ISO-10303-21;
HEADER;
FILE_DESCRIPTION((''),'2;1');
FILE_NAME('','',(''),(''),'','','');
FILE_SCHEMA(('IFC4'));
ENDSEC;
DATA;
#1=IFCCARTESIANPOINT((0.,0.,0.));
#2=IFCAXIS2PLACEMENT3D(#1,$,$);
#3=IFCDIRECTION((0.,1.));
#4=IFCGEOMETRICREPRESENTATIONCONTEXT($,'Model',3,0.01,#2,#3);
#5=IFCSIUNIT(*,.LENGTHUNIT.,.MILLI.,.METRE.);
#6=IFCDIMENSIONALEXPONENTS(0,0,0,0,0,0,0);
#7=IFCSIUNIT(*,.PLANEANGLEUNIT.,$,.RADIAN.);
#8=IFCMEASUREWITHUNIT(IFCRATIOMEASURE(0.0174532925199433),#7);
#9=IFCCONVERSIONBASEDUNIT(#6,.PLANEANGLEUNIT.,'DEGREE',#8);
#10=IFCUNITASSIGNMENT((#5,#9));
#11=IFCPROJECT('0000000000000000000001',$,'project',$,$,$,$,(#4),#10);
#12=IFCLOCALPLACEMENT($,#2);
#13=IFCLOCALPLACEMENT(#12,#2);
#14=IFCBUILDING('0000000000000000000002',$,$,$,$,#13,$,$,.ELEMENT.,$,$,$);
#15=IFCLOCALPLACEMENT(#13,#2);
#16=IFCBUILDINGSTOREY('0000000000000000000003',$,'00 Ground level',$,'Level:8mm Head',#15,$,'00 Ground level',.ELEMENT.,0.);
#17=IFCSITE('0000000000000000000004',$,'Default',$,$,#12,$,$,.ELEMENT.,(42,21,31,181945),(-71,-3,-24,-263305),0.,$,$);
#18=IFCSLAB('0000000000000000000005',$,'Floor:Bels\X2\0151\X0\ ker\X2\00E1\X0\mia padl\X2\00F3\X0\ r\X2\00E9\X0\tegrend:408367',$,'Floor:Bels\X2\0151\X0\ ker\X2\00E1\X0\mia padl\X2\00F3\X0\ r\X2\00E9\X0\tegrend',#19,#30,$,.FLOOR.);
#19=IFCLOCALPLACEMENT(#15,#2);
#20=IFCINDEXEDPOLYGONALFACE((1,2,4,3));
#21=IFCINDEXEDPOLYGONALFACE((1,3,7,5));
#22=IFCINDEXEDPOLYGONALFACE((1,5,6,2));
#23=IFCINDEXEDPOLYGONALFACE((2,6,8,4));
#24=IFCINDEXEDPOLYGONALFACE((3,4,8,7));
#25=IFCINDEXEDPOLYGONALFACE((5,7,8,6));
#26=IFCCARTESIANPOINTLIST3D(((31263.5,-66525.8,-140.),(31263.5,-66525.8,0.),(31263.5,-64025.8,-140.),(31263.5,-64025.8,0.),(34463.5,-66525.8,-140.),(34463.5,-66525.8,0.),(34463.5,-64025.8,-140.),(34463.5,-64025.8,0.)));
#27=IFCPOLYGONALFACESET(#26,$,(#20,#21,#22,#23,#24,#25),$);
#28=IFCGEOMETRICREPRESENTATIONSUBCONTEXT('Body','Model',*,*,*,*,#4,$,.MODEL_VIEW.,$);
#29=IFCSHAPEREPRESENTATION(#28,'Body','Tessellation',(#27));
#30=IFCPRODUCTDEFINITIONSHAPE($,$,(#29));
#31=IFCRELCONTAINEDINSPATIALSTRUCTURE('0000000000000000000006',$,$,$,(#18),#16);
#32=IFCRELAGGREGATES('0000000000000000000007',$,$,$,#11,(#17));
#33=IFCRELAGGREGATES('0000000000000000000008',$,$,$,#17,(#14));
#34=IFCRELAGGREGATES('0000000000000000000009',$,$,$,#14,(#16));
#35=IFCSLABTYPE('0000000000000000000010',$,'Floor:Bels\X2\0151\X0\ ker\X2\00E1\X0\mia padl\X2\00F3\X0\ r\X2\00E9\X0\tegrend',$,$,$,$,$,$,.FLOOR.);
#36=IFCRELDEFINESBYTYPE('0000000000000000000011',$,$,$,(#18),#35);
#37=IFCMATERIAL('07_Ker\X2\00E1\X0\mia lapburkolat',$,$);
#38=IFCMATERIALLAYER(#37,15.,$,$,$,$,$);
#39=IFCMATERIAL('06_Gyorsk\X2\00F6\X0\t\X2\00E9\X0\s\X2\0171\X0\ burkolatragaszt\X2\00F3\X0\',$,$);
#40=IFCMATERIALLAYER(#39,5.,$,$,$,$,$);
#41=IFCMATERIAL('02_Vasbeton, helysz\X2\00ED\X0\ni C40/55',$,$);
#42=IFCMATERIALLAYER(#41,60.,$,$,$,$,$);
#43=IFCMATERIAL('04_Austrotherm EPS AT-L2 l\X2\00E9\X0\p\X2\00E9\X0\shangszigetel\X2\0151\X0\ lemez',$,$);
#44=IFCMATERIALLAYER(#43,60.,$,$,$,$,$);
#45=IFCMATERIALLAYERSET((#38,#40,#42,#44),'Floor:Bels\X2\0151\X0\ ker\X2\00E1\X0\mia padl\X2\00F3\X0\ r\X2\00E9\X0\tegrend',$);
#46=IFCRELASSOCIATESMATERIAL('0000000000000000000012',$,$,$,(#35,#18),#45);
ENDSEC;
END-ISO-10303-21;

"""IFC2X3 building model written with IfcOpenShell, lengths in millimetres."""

from ifc_helpers import new_model, entity, si_unit, converted_unit, direction, frame, frame_2d, origin, place, context, subcontext, project, spatial, rectangle, extrude, material, layer, layer_set, layer_usage, type_object, element, save


model = new_model("IFC2X3")

# Units and contexts
model_context = context("Model", 3, precision=0.01, world=origin(), true_north=direction((0.0, 1.0)))
body_context = subcontext(model_context, "Body", "Model", "MODEL_VIEW")
ifc_project = project(units=[si_unit("LENGTHUNIT", "METRE", prefix="MILLI"), converted_unit("PLANEANGLEUNIT", "DEGREE", entity("IfcRatioMeasure", 0.0174532925199433), si_unit("PLANEANGLEUNIT", "RADIAN"), dimensions=[0, 0, 0, 0, 0, 0, 0])], contexts=[model_context])

# Site, building, storey
site_placement = place(None, origin())
site = spatial("IfcSite", under=ifc_project, at=site_placement, Name="Default", CompositionType="ELEMENT", RefLatitude=(42, 21, 31, 181945), RefLongitude=(-71, -3, -24, -263305), RefElevation=0.0)
building_placement = place(site_placement, origin())
building = spatial("IfcBuilding", under=site, at=building_placement, CompositionType="ELEMENT")
storey_placement = place(building_placement, origin())
storey = spatial("IfcBuildingStorey", under=building, at=storey_placement, Name="00 Ground level", ObjectType="Level:8mm Head", LongName="00 Ground level", CompositionType="ELEMENT", Elevation=0.0)

# Slab
ifc_material_1 = material(Name="07_Kerámia lapburkolat")
ifc_layer_1 = layer(ifc_material_1, 15.0)
ifc_material_2 = material(Name="06_Gyorskötésű burkolatragasztó")
ifc_layer_2 = layer(ifc_material_2, 5.0)
ifc_material_3 = material(Name="02_Vasbeton, helyszíni C40/55")
ifc_layer_3 = layer(ifc_material_3, 60.0)
ifc_material_4 = material(Name="04_Austrotherm EPS AT-L2 lépéshangszigetelő lemez")
ifc_layer_4 = layer(ifc_material_4, 60.0)
ifc_layer_set = layer_set([ifc_layer_1, ifc_layer_2, ifc_layer_3, ifc_layer_4], Name="Floor:Belső kerámia padló rétegrend")
ifc_layer_usage_1 = layer_usage(ifc_layer_set, "AXIS3", "POSITIVE", 0.0)
slab_type_1 = type_object("IfcSlabType", Name="Floor:Belső kerámia padló rétegrend", PredefinedType="FLOOR", material=ifc_layer_set)
slab_1_placement = place(storey_placement, origin())
element("IfcSlab", 1, at=slab_1_placement, inside=storey, type_object=slab_type_1, material=ifc_layer_usage_1, Name="Floor:Belső kerámia padló rétegrend:408367", ObjectType="Floor:Belső kerámia padló rétegrend", PredefinedType="FLOOR", context=body_context, shape_type="SweptSolid", body=[
    extrude(rectangle(XDim=2500.0, YDim=3200.0, at=frame_2d((0.0, 0.0), x_axis=(1.0, 0.0))), frame((32863.5, -65275.8, 0.0), z_axis=(0.0, 0.0, -1.0), x_axis=(0.0, 1.0, 0.0)), (0.0, 0.0, 1.0), 140.0),
])

save(model, "model.ifc")
